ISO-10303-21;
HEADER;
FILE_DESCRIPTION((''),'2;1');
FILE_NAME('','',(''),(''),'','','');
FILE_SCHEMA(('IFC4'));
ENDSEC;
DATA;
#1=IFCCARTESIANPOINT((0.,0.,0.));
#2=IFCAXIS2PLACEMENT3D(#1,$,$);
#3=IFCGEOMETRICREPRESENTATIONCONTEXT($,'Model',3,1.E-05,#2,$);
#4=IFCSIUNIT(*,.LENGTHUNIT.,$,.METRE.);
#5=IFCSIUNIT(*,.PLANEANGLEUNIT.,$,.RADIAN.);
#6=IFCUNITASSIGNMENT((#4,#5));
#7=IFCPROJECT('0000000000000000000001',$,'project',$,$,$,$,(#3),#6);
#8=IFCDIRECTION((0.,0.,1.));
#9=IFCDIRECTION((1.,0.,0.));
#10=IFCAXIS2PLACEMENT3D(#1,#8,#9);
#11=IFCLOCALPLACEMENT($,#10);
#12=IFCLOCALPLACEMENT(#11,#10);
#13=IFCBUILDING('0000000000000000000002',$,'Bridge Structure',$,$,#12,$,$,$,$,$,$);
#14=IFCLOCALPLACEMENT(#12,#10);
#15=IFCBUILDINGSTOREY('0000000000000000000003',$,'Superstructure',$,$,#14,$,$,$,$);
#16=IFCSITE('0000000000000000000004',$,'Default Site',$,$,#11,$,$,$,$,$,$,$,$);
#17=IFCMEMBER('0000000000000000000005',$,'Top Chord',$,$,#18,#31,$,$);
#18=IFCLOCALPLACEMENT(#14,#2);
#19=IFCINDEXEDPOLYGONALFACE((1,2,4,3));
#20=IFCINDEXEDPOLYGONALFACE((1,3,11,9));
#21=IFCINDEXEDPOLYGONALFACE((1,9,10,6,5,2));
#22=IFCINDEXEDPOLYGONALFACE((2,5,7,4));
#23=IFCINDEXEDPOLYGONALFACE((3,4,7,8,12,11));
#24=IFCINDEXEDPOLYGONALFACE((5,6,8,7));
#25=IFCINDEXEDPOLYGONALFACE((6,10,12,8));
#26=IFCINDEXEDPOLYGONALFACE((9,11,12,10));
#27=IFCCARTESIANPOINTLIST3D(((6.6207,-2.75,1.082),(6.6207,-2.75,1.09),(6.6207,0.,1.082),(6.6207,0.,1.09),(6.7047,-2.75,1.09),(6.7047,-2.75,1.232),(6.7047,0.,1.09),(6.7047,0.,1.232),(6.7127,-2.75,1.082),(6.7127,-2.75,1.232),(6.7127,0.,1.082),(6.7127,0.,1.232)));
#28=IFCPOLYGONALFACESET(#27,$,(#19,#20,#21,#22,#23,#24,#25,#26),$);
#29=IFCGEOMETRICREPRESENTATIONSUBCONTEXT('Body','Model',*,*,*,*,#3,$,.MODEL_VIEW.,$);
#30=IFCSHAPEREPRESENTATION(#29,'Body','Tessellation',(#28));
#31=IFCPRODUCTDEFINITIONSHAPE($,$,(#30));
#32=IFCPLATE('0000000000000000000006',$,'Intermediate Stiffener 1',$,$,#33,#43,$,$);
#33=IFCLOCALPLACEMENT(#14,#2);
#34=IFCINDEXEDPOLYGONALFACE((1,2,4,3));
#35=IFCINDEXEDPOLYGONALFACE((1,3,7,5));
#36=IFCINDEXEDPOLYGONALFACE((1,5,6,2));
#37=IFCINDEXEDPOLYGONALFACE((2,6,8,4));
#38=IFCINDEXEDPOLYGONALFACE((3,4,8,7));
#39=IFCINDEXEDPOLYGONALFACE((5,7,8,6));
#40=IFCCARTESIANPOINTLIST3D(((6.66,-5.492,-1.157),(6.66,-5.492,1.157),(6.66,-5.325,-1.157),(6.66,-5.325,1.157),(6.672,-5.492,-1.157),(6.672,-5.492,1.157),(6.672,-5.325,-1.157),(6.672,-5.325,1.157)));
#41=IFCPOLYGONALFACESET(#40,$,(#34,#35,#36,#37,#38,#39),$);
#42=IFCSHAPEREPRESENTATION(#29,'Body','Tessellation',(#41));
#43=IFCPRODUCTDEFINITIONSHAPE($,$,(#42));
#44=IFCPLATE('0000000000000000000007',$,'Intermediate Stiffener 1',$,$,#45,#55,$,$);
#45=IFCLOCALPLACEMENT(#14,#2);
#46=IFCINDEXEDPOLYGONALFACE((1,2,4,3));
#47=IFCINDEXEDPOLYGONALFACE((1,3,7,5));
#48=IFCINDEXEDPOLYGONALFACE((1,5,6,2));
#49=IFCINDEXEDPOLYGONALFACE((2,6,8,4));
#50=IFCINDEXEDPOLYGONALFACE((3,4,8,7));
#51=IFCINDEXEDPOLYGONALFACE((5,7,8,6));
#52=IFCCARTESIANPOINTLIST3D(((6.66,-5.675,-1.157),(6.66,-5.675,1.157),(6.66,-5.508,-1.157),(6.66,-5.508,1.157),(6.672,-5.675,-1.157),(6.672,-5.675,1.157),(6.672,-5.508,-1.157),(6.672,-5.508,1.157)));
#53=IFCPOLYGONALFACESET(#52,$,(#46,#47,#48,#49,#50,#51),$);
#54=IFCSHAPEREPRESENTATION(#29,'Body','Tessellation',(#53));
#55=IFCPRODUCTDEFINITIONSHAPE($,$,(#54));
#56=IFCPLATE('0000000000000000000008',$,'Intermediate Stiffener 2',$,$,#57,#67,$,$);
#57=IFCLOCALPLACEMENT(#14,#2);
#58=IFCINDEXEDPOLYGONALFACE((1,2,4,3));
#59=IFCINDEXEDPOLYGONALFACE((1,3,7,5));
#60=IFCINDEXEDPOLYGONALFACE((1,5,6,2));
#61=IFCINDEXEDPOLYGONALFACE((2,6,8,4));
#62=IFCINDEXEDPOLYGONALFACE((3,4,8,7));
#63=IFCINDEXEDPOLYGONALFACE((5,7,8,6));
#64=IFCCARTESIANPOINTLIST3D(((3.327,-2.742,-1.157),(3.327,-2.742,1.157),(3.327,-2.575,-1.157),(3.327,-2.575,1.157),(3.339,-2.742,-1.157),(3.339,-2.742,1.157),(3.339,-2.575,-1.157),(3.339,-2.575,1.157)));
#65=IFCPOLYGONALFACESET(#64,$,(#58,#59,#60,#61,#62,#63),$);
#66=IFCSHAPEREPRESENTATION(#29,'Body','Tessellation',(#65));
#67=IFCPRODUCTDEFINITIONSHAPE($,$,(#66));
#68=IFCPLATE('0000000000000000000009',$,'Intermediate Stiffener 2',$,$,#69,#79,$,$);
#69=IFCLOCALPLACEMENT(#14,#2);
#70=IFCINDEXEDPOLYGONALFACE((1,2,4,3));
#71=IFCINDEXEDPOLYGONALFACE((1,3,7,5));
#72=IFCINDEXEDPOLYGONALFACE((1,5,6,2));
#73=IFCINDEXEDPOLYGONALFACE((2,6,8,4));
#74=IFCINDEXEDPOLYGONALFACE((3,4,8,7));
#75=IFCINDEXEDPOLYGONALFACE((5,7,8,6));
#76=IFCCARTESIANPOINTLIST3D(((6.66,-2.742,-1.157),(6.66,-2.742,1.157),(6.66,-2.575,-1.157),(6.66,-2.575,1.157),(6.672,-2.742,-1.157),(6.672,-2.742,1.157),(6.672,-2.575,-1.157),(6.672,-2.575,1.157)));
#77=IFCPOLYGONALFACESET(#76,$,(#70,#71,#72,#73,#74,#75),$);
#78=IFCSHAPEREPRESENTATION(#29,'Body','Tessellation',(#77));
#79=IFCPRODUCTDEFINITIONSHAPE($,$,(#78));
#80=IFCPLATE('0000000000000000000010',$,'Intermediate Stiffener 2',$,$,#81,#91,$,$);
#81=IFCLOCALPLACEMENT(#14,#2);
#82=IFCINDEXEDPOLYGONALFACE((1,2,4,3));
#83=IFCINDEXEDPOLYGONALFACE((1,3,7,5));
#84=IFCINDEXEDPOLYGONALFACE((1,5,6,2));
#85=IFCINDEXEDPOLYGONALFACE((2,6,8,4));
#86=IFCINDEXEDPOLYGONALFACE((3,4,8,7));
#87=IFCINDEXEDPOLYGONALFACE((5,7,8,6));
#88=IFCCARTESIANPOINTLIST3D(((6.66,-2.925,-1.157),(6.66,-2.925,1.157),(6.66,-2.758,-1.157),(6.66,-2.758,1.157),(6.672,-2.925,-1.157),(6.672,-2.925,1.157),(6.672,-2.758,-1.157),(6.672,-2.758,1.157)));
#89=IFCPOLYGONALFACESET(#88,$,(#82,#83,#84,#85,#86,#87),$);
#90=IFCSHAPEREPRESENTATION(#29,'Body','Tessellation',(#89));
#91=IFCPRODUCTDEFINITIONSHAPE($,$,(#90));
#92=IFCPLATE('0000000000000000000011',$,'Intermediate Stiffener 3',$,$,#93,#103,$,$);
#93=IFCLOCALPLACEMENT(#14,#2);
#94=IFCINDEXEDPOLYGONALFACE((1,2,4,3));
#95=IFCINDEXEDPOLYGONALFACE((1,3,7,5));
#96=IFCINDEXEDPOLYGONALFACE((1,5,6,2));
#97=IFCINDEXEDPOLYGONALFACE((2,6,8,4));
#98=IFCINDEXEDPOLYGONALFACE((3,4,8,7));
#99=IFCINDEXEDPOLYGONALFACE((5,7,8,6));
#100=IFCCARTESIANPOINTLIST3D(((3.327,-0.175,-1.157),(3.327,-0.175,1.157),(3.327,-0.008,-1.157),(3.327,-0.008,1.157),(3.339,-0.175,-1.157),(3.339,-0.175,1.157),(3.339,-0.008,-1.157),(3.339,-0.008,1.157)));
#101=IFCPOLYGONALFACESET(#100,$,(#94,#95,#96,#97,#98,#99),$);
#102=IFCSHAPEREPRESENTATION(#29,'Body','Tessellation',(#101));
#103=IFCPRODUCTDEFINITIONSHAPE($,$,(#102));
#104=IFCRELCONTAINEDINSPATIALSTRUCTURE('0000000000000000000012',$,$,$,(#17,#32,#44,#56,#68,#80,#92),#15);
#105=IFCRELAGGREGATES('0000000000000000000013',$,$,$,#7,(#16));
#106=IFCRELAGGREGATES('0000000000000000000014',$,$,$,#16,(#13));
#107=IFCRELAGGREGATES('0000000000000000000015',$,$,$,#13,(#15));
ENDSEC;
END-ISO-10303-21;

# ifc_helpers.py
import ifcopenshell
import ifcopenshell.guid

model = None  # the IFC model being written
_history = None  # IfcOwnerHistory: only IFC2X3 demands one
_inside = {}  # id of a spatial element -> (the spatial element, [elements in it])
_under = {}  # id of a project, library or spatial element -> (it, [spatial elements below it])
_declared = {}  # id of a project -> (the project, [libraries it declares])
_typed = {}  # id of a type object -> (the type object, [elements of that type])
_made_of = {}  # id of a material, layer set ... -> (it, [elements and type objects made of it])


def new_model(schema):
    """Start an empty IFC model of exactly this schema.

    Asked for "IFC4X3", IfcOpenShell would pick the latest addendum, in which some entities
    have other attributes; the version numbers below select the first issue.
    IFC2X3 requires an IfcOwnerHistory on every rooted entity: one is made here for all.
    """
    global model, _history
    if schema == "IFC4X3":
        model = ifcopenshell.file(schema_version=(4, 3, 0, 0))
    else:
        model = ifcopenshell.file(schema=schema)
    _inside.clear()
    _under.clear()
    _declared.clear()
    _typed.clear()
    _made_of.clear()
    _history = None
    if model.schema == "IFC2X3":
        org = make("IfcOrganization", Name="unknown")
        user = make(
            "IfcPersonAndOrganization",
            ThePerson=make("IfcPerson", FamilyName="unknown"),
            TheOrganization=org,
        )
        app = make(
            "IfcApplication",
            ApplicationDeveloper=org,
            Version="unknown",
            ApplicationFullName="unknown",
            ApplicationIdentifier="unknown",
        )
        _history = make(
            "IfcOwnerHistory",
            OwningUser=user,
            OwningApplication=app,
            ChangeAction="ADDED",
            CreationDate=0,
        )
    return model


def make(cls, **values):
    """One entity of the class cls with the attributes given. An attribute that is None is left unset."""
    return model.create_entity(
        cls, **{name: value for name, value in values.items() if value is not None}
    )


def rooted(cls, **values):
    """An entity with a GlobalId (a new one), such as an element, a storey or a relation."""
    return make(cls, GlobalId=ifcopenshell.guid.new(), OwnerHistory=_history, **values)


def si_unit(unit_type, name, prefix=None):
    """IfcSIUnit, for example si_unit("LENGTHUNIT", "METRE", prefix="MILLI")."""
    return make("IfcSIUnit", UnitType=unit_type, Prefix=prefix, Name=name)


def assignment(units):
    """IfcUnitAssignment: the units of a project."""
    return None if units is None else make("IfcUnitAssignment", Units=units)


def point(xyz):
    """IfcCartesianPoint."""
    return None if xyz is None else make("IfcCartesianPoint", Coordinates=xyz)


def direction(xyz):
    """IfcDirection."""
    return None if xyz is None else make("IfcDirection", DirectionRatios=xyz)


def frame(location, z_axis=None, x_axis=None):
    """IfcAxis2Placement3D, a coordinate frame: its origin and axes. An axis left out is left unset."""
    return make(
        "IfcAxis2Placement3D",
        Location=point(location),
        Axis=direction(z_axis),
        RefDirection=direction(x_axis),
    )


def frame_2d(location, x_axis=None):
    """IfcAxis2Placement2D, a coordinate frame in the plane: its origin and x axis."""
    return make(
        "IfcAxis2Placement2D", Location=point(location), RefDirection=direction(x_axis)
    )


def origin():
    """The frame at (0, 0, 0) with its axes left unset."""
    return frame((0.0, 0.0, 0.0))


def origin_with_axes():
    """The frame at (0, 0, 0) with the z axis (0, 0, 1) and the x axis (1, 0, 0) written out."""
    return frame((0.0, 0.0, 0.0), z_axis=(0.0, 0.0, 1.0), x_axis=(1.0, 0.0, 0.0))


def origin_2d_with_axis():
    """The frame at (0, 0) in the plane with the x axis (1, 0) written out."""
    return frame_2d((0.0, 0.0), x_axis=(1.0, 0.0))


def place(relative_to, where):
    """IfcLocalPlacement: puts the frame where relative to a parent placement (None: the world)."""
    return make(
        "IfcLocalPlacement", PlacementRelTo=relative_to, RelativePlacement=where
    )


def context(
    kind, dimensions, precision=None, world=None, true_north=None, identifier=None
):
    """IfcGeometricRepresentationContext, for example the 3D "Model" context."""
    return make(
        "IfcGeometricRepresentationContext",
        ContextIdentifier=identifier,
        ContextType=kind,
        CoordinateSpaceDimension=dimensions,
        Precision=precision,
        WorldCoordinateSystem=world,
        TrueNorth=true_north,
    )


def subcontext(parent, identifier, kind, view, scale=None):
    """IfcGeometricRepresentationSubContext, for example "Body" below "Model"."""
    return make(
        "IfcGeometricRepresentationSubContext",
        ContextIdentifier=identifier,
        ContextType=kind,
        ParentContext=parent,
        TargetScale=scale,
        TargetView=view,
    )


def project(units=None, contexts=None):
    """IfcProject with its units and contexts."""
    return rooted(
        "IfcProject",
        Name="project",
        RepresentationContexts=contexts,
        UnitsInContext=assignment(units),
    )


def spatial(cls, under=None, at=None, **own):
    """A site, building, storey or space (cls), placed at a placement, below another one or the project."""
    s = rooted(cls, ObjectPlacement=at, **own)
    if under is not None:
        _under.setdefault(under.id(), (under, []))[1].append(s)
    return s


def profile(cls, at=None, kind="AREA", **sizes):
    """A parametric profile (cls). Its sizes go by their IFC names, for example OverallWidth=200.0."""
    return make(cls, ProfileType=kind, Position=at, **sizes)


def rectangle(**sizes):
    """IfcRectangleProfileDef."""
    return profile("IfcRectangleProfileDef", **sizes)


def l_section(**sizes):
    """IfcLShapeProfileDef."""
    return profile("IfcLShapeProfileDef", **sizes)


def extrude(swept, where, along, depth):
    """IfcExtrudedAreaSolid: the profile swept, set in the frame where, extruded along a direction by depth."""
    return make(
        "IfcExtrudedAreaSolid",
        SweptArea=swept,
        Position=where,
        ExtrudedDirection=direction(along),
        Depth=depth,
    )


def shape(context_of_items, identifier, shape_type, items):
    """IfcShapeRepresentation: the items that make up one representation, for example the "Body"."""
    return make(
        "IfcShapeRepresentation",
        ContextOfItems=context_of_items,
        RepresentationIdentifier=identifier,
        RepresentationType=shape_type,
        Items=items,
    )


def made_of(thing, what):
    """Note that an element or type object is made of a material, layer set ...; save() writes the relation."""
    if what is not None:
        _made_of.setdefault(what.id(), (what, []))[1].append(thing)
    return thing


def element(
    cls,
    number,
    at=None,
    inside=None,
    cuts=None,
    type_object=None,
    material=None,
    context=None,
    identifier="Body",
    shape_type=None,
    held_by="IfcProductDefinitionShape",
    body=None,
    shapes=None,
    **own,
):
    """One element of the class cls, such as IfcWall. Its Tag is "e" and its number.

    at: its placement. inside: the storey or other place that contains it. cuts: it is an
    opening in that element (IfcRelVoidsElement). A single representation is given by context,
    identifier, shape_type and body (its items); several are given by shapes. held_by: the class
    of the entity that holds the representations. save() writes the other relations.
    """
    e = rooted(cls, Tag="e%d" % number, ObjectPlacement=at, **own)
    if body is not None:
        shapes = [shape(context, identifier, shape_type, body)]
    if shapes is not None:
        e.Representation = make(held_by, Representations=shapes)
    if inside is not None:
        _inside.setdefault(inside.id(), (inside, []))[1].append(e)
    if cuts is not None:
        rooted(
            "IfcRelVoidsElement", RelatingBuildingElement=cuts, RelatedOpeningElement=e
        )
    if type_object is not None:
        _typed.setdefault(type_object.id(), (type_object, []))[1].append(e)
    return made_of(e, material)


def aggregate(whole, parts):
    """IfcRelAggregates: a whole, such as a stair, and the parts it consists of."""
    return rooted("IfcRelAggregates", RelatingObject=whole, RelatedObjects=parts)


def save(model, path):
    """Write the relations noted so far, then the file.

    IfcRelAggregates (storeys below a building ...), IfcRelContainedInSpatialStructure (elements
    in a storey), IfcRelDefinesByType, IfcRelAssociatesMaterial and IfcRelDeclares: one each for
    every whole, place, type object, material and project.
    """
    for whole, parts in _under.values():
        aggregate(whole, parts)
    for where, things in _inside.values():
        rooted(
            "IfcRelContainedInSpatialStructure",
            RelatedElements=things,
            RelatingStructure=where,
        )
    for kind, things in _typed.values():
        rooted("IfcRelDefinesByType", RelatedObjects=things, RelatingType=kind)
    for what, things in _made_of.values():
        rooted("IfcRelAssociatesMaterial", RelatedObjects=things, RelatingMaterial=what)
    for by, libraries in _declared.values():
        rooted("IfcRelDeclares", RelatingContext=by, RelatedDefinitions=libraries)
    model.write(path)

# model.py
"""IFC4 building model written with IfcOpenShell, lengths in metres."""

from ifc_helpers import new_model, si_unit, frame, origin, origin_with_axes, origin_2d_with_axis, place, context, subcontext, project, spatial, rectangle, l_section, extrude, element, save


model = new_model("IFC4")

# Units and contexts
model_context = context("Model", 3, precision=1e-05, world=origin())
body_context = subcontext(model_context, "Body", "Model", "MODEL_VIEW")
ifc_project = project(units=[si_unit("LENGTHUNIT", "METRE"), si_unit("PLANEANGLEUNIT", "RADIAN")], contexts=[model_context])

# Site, building, storey
site_placement = place(None, origin_with_axes())
site = spatial("IfcSite", under=ifc_project, at=site_placement, Name="Default Site")
building_placement = place(site_placement, origin_with_axes())
building = spatial("IfcBuilding", under=site, at=building_placement, Name="Bridge Structure")
storey_placement = place(building_placement, origin_with_axes())
storey = spatial("IfcBuildingStorey", under=building, at=storey_placement, Name="Superstructure")

# Member
for number, where, z_axis, x_axis, name in (
    (1, (6.6667, -2.75, 1.157), (0.0, 1.0, 0.0), (-1.0, 0.0, 0.0), "Top Chord"),
):
    element("IfcMember", number, at=place(storey_placement, frame(where, z_axis=z_axis, x_axis=x_axis)), inside=storey, Name=name, context=body_context, shape_type="SweptSolid", body=[
        extrude(l_section(Depth=0.15, Width=0.092, Thickness=0.008, at=origin_2d_with_axis()), origin_with_axes(), (0.0, 0.0, 1.0), 2.75),
    ])

# Plates
for number, where, z_axis, x_axis, name in (
    (2, (6.666, -5.4085, -1.157), (0.0, 0.0, 1.0), (1.0, 0.0, 0.0), "Intermediate Stiffener 1"),
    (3, (6.666, -5.5915, -1.157), (0.0, 0.0, 1.0), (1.0, 0.0, 0.0), "Intermediate Stiffener 1"),
    (4, (3.333, -2.6585, -1.157), (0.0, 0.0, 1.0), (1.0, 0.0, 0.0), "Intermediate Stiffener 2"),
    (5, (6.666, -2.6585, -1.157), (0.0, 0.0, 1.0), (1.0, 0.0, 0.0), "Intermediate Stiffener 2"),
    (6, (6.666, -2.8415, -1.157), (0.0, 0.0, 1.0), (1.0, 0.0, 0.0), "Intermediate Stiffener 2"),
    (7, (3.333, -0.0915, -1.157), (0.0, 0.0, 1.0), (1.0, 0.0, 0.0), "Intermediate Stiffener 3"),
):
    element("IfcPlate", number, at=place(storey_placement, frame(where, z_axis=z_axis, x_axis=x_axis)), inside=storey, Name=name, context=body_context, shape_type="SweptSolid", body=[
        extrude(rectangle(XDim=0.012, YDim=0.167, at=origin_2d_with_axis()), origin_with_axes(), (0.0, 0.0, 1.0), 2.314),
    ])

save(model, "model.ifc")
